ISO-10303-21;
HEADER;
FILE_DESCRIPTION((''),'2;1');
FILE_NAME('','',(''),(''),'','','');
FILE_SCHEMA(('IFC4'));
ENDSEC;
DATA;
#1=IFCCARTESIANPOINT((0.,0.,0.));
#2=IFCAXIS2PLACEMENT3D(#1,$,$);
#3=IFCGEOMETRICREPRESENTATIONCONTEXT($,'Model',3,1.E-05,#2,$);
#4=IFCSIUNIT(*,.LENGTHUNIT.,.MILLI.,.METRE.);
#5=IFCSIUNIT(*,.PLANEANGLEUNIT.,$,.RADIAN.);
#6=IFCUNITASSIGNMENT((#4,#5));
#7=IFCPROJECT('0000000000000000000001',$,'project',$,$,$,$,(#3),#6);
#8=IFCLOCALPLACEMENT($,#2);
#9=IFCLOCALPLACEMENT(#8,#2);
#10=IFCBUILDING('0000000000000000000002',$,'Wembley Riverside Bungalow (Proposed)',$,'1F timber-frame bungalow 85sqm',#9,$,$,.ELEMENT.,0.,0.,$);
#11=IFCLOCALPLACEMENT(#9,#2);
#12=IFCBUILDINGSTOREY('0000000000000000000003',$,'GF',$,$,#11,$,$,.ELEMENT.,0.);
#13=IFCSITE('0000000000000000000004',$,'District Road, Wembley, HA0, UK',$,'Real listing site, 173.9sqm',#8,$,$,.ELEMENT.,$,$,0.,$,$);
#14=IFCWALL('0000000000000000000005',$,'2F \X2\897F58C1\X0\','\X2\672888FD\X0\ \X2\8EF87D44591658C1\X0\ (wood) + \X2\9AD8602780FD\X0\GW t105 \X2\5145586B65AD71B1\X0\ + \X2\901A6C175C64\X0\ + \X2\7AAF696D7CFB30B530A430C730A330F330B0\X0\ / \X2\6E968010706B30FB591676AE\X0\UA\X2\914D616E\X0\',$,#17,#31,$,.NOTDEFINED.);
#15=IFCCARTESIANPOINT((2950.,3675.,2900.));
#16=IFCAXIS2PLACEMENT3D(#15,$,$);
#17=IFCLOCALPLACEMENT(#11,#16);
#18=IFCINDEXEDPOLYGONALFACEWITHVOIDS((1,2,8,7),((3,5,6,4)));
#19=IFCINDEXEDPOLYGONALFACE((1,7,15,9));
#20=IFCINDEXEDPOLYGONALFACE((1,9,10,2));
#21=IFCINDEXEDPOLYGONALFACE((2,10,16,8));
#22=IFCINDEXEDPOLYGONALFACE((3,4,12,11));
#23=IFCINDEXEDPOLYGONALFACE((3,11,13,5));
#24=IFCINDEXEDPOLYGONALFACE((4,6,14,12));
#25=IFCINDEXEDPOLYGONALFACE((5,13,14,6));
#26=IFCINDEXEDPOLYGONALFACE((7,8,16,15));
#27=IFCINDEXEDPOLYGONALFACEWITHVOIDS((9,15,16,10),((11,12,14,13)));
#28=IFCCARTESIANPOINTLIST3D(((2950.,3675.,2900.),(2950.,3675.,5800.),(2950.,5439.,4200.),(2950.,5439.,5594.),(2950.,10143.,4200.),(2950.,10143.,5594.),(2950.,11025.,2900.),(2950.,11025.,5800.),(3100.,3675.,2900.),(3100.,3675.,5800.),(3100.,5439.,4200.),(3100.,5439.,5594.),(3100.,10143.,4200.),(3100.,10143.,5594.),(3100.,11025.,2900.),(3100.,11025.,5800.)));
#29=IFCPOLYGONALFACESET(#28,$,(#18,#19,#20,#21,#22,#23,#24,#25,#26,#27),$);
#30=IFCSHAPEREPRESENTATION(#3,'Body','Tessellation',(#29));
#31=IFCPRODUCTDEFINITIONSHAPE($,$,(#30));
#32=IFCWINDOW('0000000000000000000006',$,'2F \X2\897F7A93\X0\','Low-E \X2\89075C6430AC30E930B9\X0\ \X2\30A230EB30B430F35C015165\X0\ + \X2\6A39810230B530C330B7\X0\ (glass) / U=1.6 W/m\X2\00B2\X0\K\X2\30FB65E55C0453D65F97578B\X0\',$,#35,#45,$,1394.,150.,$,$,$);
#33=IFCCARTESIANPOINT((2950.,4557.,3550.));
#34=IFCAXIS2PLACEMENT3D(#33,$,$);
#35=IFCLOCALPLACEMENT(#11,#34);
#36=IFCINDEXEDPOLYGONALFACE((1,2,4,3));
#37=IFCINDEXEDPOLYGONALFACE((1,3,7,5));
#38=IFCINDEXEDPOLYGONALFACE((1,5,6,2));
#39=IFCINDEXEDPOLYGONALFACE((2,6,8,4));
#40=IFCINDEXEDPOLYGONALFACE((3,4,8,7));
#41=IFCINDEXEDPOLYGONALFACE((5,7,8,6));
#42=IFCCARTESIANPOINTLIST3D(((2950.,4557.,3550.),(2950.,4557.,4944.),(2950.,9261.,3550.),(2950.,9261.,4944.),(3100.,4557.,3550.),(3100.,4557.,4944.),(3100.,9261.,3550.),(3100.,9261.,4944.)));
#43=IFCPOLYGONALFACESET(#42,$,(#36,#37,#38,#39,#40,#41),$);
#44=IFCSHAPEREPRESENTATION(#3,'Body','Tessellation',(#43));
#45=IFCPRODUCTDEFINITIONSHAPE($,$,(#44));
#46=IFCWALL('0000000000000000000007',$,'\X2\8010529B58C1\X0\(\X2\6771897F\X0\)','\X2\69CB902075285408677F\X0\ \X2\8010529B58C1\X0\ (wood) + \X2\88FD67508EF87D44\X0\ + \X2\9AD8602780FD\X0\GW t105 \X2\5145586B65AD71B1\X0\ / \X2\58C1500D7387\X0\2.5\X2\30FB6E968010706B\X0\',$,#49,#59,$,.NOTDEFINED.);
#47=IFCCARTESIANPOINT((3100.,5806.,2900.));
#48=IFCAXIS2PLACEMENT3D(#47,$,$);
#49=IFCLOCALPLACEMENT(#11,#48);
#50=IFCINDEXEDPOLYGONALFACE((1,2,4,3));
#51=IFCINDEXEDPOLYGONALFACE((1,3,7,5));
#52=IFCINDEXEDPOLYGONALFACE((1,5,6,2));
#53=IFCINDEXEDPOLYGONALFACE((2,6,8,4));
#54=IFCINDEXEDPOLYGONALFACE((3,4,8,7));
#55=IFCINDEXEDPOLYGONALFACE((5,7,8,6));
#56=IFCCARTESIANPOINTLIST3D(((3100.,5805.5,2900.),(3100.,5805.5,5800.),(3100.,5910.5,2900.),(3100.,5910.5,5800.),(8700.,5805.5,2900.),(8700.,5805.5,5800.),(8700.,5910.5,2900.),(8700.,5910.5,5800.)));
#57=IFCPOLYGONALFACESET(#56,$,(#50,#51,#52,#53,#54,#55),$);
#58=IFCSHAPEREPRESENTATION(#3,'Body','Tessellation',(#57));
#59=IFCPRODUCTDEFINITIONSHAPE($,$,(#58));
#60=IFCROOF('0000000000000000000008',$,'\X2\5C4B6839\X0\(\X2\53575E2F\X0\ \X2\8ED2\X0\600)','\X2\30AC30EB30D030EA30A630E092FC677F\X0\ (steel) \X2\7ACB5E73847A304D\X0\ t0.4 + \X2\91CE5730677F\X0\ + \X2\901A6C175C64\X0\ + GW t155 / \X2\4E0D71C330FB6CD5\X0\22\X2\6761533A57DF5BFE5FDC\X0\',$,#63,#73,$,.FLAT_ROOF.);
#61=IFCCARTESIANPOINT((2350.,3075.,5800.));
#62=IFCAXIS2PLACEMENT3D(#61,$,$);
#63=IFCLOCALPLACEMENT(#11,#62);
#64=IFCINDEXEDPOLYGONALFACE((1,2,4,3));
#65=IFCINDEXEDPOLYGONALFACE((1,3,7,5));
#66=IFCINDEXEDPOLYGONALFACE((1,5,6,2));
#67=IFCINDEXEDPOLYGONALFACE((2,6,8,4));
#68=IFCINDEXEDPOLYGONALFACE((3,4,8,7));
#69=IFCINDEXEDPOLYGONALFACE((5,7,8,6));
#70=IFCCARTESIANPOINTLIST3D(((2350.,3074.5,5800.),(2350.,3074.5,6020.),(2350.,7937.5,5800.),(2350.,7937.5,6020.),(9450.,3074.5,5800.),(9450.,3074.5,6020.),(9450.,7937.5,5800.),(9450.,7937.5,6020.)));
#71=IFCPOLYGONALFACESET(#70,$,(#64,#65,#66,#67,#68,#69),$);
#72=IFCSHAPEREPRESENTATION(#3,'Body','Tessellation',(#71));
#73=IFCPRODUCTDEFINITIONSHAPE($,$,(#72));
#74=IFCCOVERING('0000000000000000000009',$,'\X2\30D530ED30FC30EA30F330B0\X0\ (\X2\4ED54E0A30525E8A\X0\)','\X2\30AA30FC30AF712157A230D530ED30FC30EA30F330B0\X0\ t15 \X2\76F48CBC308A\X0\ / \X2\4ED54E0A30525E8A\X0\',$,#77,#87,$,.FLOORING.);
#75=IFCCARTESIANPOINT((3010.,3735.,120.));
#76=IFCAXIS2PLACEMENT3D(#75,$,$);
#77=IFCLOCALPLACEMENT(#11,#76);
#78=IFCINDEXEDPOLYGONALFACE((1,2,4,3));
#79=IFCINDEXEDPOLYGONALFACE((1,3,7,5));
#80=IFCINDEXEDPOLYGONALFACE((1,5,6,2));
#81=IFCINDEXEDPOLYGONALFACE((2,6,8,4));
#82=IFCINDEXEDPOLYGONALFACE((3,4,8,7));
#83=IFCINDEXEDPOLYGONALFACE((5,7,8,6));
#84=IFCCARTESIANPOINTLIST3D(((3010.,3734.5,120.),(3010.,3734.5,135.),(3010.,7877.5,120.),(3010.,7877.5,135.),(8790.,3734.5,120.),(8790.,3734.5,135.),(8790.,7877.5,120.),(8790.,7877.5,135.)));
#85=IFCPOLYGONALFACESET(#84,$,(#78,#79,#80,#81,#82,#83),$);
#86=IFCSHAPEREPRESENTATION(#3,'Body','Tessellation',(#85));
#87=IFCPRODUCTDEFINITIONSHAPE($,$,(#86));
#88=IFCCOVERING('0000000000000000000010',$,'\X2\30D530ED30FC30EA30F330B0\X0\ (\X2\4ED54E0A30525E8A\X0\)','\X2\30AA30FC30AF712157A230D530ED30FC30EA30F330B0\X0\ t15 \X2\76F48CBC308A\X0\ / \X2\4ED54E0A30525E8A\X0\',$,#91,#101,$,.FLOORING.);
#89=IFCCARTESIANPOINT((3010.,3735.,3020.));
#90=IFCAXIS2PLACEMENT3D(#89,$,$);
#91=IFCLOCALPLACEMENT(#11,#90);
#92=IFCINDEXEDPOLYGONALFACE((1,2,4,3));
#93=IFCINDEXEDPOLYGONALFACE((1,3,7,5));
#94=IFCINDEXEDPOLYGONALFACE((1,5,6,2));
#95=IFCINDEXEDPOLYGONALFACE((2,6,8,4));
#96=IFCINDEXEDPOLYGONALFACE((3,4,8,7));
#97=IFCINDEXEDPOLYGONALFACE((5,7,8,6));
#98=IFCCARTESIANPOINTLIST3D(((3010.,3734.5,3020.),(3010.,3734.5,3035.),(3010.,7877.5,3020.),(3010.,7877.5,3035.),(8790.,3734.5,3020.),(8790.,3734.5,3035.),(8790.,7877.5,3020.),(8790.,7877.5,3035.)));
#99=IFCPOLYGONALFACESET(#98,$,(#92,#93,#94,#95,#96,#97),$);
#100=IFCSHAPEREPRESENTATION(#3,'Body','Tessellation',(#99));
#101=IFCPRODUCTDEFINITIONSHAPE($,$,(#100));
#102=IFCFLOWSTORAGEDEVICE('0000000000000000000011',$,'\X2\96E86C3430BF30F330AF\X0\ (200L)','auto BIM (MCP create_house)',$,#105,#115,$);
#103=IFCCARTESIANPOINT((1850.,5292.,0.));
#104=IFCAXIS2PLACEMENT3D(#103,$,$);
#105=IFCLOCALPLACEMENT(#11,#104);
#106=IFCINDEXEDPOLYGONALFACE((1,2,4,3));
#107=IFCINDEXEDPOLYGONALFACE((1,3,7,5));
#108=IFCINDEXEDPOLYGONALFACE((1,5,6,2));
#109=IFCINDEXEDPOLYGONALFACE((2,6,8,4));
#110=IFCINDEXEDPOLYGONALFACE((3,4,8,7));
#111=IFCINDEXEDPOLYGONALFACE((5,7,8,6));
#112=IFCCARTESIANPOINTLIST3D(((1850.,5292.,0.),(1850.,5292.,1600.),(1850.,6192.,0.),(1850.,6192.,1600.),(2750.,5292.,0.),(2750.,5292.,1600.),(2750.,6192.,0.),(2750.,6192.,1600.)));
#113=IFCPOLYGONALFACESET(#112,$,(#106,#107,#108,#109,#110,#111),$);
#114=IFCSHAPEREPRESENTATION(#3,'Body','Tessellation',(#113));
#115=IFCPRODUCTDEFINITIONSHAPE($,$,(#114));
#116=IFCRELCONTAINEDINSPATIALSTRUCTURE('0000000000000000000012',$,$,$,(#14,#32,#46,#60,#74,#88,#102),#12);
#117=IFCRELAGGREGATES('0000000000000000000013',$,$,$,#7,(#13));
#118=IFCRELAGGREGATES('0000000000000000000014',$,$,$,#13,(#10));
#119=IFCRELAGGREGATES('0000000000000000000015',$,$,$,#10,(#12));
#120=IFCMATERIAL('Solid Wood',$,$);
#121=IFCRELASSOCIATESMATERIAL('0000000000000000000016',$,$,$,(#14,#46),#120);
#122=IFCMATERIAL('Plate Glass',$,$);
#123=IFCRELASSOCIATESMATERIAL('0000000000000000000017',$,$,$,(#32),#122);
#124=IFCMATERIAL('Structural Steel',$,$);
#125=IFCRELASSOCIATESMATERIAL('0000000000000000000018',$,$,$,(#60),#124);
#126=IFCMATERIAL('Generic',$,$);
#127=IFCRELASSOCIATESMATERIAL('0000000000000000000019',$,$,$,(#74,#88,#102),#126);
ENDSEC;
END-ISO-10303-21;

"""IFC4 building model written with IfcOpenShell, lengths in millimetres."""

from ifc_helpers import new_model, si_unit, frame, frame_2d, origin, place, context, project, spatial, rectangle, extrude, material, element, fill, save


model = new_model("IFC4")

# Units and contexts
model_context = context("Model", 3, precision=1e-05, world=origin())
ifc_project = project(units=[si_unit("LENGTHUNIT", "METRE", prefix="MILLI"), si_unit("PLANEANGLEUNIT", "RADIAN")], contexts=[model_context])

# Site, building, storey
site_placement = place(None, origin())
site = spatial("IfcSite", under=ifc_project, at=site_placement, Name="District Road, Wembley, HA0, UK", ObjectType="Real listing site, 173.9sqm", CompositionType="ELEMENT", RefElevation=0.0)
building_placement = place(site_placement, origin())
building = spatial("IfcBuilding", under=site, at=building_placement, Name="Wembley Riverside Bungalow (Proposed)", ObjectType="1F timber-frame bungalow 85sqm", CompositionType="ELEMENT", ElevationOfRefHeight=0.0, ElevationOfTerrain=0.0)
storey_placement = place(building_placement, origin())
storey = spatial("IfcBuildingStorey", under=building, at=storey_placement, Name="GF", CompositionType="ELEMENT", Elevation=0.0)

# Shared definitions
ifc_material_1 = material(Name="Solid Wood")
ifc_material_2 = material(Name="Generic")

# Shared definitions
ifc_material_3 = material(Name="Plate Glass")

# Wall, opening, window
wall_1_placement = place(storey_placement, frame((2950.0, 3675.0, 2900.0)))
wall_1 = element("IfcWall", 1, at=wall_1_placement, inside=storey, material=ifc_material_1, Name="2F 西壁", Description="木製 軸組外壁 (wood) + 高性能GW t105 充填断熱 + 通気層 + 窯業系サイディング / 準耐火・外皮UA配慮", PredefinedType="NOTDEFINED", context=model_context, shape_type="SweptSolid", body=[
    extrude(rectangle(XDim=150.0, YDim=7350.0, at=frame_2d((75.0, 3675.0))), frame((2950.0, 3675.0, 2900.0)), (0.0, 0.0, 1.0), 2900.0),
])
opening_1_placement = place(storey_placement, frame((2950.0, 4557.0, 3550.0)))
opening_1 = element("IfcOpeningElement", 2, at=opening_1_placement, cuts=wall_1, PredefinedType="NOTDEFINED", context=model_context, shape_type="SweptSolid", body=[
    extrude(rectangle(XDim=150.0, YDim=4704.0, at=frame_2d((75.0, 2352.0))), frame((2950.0, 4557.0, 3550.0)), (0.0, 0.0, 1.0), 1394.0),
])
window_1_placement = place(storey_placement, frame((2950.0, 4557.0, 3550.0)))
window_1 = element("IfcWindow", 3, at=window_1_placement, inside=storey, material=ifc_material_3, Name="2F 西窓", Description="Low-E 複層ガラス アルゴン封入 + 樹脂サッシ (glass) / U=1.6 W/m²K・日射取得型", OverallHeight=1394.0, OverallWidth=150.0, context=model_context, shape_type="SweptSolid", body=[
    extrude(rectangle(XDim=150.0, YDim=4704.0, at=frame_2d((75.0, 2352.0))), frame((2950.0, 4557.0, 3550.0)), (0.0, 0.0, 1.0), 1394.0),
])
fill(opening_1, window_1)

# Wall
wall_2_placement = place(storey_placement, frame((3100.0, 5806.0, 2900.0)))
element("IfcWall", 4, at=wall_2_placement, inside=storey, material=ifc_material_1, Name="耐力壁(東西)", Description="構造用合板 耐力壁 (wood) + 製材軸組 + 高性能GW t105 充填断熱 / 壁倍率2.5・準耐火", PredefinedType="NOTDEFINED", context=model_context, shape_type="SweptSolid", body=[
    extrude(rectangle(XDim=5600.0, YDim=105.0, at=frame_2d((2800.0, 52.0))), frame((3100.0, 5806.0, 2900.0)), (0.0, 0.0, 1.0), 2900.0),
])

# Roof
ifc_material_4 = material(Name="Structural Steel")
for number, where, name in (
    (5, (2350.0, 3075.0, 5800.0), "屋根(南帯 軒600)"),
):
    element("IfcRoof", number, at=place(storey_placement, frame(where)), inside=storey, material=ifc_material_4, Name=name, Description="ガルバリウム鋼板 (steel) 立平葺き t0.4 + 野地板 + 通気層 + GW t155 / 不燃・法22条区域対応", PredefinedType="FLAT_ROOF", context=model_context, shape_type="SweptSolid", body=[
        extrude(rectangle(XDim=7100.0, YDim=4863.0, at=frame_2d((3550.0, 2431.0))), frame((2350.0, 3075.0, 5800.0)), (0.0, 0.0, 1.0), 220.0),
    ])

# Coverings
covering_1_placement = place(storey_placement, frame((3010.0, 3735.0, 120.0)))
element("IfcCovering", 6, at=covering_1_placement, inside=storey, material=ifc_material_2, Name="フローリング (仕上げ床)", Description="オーク無垢フローリング t15 直貼り / 仕上げ床", PredefinedType="FLOORING", context=model_context, shape_type="SweptSolid", body=[
    extrude(rectangle(XDim=5780.0, YDim=4143.0, at=frame_2d((2890.0, 2071.0))), frame((3010.0, 3735.0, 120.0)), (0.0, 0.0, 1.0), 15.0),
])
covering_2_placement = place(storey_placement, frame((3010.0, 3735.0, 3020.0)))
element("IfcCovering", 7, at=covering_2_placement, inside=storey, material=ifc_material_2, Name="フローリング (仕上げ床)", Description="オーク無垢フローリング t15 直貼り / 仕上げ床", PredefinedType="FLOORING", context=model_context, shape_type="SweptSolid", body=[
    extrude(rectangle(XDim=5780.0, YDim=4143.0, at=frame_2d((2890.0, 2071.0))), frame((3010.0, 3735.0, 3020.0)), (0.0, 0.0, 1.0), 15.0),
])

# Flow storage device
flow_storage_device_placement = place(storey_placement, frame((1850.0, 5292.0, 0.0)))
element("IfcFlowStorageDevice", 8, at=flow_storage_device_placement, inside=storey, material=ifc_material_2, Name="雨水タンク (200L)", Description="auto BIM (MCP create_house)", context=model_context, shape_type="SweptSolid", body=[
    extrude(rectangle(XDim=900.0, YDim=900.0, at=frame_2d((450.0, 450.0))), frame((1850.0, 5292.0, 0.0)), (0.0, 0.0, 1.0), 1600.0),
])

save(model, "model.ifc")
